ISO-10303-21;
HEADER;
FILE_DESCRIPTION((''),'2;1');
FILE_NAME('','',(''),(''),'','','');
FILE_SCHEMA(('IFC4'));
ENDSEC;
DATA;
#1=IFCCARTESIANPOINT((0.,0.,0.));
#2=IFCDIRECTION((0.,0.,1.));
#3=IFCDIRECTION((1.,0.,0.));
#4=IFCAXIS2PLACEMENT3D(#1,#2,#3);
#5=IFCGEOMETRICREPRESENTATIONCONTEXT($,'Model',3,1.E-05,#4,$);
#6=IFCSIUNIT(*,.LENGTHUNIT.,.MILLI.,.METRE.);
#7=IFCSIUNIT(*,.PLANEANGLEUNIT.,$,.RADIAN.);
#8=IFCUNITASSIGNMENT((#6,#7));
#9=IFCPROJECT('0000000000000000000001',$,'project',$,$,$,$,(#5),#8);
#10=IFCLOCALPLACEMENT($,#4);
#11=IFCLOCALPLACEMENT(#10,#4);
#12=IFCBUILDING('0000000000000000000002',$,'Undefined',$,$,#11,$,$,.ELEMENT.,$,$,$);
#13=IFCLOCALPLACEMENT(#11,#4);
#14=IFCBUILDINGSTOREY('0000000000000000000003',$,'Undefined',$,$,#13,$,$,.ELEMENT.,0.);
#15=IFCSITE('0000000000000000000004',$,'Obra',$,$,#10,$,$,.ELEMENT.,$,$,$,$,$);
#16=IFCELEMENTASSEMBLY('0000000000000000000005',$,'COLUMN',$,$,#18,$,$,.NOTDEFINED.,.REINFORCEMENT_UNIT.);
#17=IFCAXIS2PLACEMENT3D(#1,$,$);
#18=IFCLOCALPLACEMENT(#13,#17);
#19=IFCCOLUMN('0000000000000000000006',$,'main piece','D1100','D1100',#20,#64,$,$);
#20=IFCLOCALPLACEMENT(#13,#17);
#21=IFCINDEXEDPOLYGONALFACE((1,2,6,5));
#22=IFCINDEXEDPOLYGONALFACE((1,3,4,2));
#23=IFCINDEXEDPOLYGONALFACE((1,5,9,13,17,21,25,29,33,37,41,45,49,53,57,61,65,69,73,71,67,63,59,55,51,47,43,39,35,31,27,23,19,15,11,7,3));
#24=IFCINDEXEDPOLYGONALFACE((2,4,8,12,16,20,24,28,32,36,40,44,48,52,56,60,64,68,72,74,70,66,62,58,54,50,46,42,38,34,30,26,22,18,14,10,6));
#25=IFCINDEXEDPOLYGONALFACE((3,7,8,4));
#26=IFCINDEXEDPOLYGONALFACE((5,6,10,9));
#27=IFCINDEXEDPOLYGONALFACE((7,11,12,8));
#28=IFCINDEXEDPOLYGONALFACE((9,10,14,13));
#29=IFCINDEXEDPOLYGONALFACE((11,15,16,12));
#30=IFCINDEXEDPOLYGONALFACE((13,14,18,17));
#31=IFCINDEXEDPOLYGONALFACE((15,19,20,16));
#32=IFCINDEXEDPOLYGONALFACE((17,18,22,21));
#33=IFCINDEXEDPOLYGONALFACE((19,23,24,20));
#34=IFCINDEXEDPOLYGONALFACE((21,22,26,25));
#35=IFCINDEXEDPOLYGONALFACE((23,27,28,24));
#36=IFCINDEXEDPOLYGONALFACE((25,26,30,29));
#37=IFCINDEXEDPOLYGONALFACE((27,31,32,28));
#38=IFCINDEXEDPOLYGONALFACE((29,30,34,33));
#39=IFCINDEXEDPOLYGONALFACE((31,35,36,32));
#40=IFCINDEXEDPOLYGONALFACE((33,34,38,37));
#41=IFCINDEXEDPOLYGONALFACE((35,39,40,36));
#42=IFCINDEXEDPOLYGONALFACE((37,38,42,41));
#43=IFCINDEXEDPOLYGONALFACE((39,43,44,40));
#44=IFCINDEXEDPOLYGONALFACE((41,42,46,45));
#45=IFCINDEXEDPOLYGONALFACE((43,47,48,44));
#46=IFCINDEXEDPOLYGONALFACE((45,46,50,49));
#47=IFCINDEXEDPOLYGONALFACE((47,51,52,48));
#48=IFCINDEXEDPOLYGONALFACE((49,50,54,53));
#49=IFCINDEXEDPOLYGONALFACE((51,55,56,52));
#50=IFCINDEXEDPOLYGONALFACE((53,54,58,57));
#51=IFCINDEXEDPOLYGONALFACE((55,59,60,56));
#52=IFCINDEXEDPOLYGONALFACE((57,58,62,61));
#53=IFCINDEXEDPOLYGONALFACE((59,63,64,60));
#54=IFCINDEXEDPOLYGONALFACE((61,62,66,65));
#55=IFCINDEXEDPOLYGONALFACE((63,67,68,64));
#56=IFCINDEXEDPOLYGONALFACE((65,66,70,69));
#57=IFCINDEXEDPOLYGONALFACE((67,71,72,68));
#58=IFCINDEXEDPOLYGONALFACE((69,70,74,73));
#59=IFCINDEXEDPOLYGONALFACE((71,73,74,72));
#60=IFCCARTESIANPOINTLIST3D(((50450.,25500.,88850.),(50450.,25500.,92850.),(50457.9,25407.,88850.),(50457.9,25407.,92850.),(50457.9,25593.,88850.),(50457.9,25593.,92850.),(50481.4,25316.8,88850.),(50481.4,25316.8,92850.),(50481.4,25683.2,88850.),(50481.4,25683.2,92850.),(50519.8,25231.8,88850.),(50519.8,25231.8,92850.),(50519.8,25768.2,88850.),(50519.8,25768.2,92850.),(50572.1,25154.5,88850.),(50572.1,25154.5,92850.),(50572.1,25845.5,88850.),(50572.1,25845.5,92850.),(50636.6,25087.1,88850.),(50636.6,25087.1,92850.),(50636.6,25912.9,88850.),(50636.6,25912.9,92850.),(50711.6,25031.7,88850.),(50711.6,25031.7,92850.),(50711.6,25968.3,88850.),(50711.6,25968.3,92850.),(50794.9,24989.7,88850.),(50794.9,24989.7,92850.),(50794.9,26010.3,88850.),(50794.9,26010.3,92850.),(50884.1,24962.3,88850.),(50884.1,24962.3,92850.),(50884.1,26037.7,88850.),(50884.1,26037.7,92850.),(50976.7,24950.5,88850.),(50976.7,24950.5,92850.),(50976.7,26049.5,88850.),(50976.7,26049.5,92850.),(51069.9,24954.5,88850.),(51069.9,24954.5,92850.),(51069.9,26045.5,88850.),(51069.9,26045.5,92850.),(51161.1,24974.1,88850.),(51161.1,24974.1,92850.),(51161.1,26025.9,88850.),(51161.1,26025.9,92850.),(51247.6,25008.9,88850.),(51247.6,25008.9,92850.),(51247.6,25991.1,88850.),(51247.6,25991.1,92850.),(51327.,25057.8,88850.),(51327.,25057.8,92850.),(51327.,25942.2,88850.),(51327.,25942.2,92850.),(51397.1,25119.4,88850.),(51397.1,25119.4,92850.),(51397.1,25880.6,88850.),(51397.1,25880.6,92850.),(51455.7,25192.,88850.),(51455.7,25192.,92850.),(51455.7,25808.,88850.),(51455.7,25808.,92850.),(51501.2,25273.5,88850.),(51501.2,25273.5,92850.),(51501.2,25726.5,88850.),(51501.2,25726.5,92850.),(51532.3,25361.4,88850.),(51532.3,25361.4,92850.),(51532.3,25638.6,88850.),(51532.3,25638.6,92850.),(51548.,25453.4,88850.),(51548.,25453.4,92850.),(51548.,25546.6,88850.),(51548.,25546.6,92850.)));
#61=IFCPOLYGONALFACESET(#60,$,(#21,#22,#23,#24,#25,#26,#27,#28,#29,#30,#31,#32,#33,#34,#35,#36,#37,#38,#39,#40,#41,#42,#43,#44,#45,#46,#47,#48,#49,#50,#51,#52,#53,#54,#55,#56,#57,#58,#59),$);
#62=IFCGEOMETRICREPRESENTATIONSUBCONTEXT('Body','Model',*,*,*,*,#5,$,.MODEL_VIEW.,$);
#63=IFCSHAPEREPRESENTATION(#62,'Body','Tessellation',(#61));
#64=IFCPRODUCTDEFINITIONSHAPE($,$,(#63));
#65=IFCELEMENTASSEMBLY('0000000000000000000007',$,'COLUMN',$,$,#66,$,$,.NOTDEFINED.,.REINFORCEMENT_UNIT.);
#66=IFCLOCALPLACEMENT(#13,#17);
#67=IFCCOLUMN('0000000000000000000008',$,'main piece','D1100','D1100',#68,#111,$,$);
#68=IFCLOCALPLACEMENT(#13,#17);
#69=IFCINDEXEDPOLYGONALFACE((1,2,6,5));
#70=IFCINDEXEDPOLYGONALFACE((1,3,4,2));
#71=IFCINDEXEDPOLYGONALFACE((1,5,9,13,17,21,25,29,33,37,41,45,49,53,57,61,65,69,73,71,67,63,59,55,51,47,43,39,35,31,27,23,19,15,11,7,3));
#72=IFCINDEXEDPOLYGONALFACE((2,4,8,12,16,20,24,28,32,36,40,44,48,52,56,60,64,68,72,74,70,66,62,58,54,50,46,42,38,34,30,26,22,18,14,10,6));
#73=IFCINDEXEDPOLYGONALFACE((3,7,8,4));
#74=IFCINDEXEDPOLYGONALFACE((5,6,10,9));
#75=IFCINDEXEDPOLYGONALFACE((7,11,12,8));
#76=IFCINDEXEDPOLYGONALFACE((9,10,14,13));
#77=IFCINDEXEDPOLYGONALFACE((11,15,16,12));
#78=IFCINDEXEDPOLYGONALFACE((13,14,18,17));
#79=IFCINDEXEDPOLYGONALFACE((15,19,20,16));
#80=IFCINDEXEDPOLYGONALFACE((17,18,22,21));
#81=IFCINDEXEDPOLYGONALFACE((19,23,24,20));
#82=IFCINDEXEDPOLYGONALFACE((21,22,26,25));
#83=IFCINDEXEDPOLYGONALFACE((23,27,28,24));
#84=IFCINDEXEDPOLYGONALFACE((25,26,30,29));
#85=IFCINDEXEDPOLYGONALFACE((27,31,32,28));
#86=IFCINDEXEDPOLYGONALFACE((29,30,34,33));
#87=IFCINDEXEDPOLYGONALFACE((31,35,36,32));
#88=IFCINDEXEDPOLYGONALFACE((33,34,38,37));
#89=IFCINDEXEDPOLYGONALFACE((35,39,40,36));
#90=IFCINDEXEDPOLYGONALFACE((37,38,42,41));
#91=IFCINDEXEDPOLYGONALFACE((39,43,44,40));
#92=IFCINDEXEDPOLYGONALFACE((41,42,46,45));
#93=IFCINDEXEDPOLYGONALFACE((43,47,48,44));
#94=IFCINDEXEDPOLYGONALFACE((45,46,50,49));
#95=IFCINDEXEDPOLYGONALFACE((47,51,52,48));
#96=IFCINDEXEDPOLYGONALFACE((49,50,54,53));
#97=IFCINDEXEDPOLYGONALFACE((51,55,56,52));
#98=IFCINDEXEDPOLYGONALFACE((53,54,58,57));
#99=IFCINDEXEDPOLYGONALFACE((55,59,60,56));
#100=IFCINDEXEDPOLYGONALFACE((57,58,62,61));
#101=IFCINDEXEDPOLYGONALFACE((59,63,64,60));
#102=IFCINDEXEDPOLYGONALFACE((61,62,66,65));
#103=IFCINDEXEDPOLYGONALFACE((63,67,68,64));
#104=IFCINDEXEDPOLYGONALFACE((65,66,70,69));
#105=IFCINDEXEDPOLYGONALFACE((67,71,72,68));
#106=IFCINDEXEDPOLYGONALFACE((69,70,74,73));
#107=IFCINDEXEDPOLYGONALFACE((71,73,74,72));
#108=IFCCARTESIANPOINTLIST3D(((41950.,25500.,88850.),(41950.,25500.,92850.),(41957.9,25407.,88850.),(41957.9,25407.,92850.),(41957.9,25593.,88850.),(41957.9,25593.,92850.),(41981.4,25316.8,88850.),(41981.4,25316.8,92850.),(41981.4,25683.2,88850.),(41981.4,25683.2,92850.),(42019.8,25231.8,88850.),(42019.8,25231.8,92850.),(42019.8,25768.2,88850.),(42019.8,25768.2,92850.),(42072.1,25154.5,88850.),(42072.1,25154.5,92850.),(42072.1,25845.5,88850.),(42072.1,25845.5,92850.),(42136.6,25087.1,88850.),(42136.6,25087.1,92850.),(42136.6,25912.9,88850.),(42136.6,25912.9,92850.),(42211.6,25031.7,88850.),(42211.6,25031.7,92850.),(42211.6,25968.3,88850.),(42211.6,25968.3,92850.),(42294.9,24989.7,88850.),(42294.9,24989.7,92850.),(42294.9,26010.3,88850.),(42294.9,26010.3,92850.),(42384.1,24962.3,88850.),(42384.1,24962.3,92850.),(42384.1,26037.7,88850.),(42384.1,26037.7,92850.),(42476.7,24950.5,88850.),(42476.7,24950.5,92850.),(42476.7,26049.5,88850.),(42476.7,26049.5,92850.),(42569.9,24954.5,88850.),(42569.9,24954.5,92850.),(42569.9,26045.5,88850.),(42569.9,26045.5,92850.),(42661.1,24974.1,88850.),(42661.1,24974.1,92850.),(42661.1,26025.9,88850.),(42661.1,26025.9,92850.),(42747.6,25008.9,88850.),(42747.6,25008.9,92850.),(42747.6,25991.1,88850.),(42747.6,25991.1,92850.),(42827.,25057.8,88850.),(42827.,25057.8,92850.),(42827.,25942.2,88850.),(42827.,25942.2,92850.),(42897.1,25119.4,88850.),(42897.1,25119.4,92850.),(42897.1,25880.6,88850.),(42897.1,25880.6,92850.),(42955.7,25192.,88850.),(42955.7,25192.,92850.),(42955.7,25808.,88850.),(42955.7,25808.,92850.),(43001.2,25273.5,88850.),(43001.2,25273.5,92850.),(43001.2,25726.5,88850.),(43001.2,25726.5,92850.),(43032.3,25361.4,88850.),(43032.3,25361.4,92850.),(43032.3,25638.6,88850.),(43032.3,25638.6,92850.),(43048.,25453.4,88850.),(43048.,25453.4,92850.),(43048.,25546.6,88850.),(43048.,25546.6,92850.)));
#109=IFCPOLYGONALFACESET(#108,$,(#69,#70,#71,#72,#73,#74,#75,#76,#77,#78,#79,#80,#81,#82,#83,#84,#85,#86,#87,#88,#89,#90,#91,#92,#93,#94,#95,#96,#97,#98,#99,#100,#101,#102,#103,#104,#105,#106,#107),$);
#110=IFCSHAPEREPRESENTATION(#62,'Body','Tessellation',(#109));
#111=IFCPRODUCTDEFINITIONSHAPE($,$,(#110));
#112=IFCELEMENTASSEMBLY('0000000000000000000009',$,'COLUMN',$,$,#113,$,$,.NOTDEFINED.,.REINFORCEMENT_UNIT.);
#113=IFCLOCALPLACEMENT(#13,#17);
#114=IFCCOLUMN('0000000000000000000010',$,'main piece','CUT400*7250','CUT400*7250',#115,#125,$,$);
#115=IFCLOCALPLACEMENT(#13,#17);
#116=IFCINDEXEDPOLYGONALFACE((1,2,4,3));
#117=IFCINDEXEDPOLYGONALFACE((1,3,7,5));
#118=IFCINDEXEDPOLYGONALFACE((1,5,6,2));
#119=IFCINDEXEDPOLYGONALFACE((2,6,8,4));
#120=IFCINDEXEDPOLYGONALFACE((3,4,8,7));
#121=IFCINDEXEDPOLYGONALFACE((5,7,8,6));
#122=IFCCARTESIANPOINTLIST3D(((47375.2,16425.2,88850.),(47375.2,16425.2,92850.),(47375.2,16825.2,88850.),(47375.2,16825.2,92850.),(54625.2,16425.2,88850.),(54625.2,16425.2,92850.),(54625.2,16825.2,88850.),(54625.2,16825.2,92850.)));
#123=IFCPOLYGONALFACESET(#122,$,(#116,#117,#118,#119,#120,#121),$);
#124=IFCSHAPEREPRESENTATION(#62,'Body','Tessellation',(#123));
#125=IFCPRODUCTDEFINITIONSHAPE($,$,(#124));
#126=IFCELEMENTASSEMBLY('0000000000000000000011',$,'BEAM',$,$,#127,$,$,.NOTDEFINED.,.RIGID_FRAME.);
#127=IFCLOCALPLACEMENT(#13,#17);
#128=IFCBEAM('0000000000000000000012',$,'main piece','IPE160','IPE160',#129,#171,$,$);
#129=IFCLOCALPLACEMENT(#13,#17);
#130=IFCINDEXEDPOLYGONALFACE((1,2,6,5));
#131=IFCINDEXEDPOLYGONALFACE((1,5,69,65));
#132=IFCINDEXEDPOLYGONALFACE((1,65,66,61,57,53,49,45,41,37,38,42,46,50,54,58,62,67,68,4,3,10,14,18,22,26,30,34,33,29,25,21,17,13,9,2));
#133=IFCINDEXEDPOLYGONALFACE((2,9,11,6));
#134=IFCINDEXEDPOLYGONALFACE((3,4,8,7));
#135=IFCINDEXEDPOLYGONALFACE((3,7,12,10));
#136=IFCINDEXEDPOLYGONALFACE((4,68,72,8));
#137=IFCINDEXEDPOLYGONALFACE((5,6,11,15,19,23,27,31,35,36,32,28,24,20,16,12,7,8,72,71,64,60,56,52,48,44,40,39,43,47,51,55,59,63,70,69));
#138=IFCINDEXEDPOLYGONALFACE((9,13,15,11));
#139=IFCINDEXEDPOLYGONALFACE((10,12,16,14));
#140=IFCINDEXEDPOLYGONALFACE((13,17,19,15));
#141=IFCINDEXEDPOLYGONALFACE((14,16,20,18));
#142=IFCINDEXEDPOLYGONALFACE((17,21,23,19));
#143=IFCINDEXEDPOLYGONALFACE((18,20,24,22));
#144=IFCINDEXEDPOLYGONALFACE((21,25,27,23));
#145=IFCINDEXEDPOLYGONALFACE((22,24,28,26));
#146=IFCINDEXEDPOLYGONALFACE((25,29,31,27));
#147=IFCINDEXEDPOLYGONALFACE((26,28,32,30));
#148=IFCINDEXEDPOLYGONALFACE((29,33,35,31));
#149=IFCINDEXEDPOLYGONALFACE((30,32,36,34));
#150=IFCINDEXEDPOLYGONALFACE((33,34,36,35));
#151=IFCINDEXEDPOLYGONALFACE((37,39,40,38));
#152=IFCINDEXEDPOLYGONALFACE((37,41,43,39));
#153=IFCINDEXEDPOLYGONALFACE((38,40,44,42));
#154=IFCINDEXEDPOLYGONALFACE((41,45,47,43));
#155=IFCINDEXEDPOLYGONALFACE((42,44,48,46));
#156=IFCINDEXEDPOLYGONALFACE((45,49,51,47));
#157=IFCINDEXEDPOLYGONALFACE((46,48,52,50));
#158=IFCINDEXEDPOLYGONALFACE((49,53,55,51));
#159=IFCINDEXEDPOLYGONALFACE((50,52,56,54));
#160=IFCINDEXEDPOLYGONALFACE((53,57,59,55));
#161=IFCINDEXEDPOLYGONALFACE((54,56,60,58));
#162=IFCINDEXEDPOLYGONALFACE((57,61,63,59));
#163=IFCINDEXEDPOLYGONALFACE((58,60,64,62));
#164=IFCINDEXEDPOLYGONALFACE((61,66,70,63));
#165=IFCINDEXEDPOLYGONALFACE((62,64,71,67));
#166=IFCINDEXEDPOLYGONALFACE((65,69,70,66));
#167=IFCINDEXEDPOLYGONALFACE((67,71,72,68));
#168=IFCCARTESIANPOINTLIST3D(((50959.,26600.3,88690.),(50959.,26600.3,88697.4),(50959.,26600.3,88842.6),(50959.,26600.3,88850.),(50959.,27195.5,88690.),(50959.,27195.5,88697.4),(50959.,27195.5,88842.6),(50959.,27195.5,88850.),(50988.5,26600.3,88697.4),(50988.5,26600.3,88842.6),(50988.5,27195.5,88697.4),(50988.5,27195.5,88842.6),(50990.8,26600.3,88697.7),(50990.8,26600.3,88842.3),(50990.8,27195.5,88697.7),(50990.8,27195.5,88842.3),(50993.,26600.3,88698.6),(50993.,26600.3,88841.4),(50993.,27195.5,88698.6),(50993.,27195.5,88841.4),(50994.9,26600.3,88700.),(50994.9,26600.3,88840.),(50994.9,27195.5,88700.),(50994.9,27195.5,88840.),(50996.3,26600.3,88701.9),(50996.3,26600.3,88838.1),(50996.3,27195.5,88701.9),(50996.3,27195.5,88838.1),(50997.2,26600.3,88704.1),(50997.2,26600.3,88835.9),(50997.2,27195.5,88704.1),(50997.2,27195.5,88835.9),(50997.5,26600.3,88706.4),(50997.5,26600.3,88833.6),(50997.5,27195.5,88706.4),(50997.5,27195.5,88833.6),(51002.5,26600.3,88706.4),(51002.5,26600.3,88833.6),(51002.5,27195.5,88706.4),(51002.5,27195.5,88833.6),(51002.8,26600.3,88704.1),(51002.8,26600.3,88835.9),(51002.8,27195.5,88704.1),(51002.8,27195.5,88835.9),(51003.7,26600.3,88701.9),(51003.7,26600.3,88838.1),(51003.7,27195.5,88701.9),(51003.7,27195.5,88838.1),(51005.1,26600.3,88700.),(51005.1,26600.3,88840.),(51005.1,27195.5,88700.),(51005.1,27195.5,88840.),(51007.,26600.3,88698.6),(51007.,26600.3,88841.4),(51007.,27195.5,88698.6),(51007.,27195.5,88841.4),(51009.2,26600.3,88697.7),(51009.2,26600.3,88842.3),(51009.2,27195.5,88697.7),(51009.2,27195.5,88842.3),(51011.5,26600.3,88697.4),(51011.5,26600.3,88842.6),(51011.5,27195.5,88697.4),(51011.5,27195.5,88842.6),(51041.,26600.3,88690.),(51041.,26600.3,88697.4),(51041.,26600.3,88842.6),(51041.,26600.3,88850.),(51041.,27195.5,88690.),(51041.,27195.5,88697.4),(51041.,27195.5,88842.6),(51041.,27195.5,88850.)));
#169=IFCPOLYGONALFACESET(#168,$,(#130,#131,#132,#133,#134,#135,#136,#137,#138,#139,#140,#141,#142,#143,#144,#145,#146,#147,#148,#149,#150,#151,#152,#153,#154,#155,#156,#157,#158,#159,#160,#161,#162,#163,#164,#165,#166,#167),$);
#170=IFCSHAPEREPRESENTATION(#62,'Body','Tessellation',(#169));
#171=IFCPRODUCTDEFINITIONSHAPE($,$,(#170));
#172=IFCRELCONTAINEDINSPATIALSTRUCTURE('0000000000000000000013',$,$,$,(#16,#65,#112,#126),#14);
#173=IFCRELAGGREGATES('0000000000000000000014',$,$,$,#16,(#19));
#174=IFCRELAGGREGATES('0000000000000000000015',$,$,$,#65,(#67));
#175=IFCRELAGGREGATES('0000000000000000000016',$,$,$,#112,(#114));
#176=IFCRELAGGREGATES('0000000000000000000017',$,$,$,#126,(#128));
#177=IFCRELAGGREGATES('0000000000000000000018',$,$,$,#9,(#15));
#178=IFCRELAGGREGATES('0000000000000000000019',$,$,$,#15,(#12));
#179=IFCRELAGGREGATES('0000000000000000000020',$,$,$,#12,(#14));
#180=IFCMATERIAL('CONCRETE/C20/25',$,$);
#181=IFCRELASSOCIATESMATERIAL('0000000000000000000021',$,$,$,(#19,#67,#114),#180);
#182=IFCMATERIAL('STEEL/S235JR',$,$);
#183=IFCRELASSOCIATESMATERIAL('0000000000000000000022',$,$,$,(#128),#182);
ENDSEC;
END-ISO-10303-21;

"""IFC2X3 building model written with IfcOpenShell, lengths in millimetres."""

from ifc_helpers import new_model, si_unit, frame, origin_with_axes, origin_2d_with_axis, place, context, subcontext, project, spatial, rectangle, circle, i_section, extrude, material, element, aggregate, save


model = new_model("IFC2X3")

# Units and contexts
model_context = context("Model", 3, precision=1e-05, world=origin_with_axes())
body_context = subcontext(model_context, "Body", "Model", "MODEL_VIEW")
ifc_project = project(units=[si_unit("LENGTHUNIT", "METRE", prefix="MILLI"), si_unit("PLANEANGLEUNIT", "RADIAN")], contexts=[model_context])

# Site, building, storey
site_placement = place(None, origin_with_axes())
site = spatial("IfcSite", under=ifc_project, at=site_placement, Name="Obra", CompositionType="ELEMENT")
building_placement = place(site_placement, origin_with_axes())
building = spatial("IfcBuilding", under=site, at=building_placement, Name="Undefined", CompositionType="ELEMENT")
storey_placement = place(building_placement, origin_with_axes())
storey = spatial("IfcBuildingStorey", under=building, at=storey_placement, Name="Undefined", CompositionType="ELEMENT", Elevation=0.0)

# Element assemblies, columns
assembly_1_placement = place(storey_placement, origin_with_axes())
assembly_1 = element("IfcElementAssembly", 1, at=assembly_1_placement, inside=storey, Name="COLUMN", AssemblyPlace="NOTDEFINED", PredefinedType="REINFORCEMENT_UNIT")
ifc_material_1 = material(Name="CONCRETE/C20/25")
column_1_placement = place(assembly_1_placement, frame((51000.0, 25500.0, 88850.0), z_axis=(0.0, 0.0, 1.0), x_axis=(0.0, 1.0, 0.0)))
column_1 = element("IfcColumn", 2, at=column_1_placement, material=ifc_material_1, Name="main piece", Description="D1100", ObjectType="D1100", context=body_context, shape_type="SweptSolid", body=[
    extrude(circle(Radius=550.0, at=origin_2d_with_axis()), frame((0.0, 0.0, 4000.0), z_axis=(0.0, 0.0, -1.0), x_axis=(0.0, 1.0, 0.0)), (0.0, 0.0, 1.0), 4000.0),
])
aggregate(assembly_1, [column_1])
assembly_2_placement = place(storey_placement, origin_with_axes())
assembly_2 = element("IfcElementAssembly", 3, at=assembly_2_placement, inside=storey, Name="COLUMN", AssemblyPlace="NOTDEFINED", PredefinedType="REINFORCEMENT_UNIT")
column_2_placement = place(assembly_2_placement, frame((42500.0, 25500.0, 88850.0), z_axis=(0.0, 0.0, 1.0), x_axis=(0.0, 1.0, 0.0)))
column_2 = element("IfcColumn", 4, at=column_2_placement, material=ifc_material_1, Name="main piece", Description="D1100", ObjectType="D1100", context=body_context, shape_type="SweptSolid", body=[
    extrude(circle(Radius=550.0, at=origin_2d_with_axis()), frame((0.0, 0.0, 4000.0), z_axis=(0.0, 0.0, -1.0), x_axis=(0.0, 1.0, 0.0)), (0.0, 0.0, 1.0), 4000.0),
])
aggregate(assembly_2, [column_2])
assembly_3_placement = place(storey_placement, origin_with_axes())
assembly_3 = element("IfcElementAssembly", 5, at=assembly_3_placement, inside=storey, Name="COLUMN", AssemblyPlace="NOTDEFINED", PredefinedType="REINFORCEMENT_UNIT")
column_3_placement = place(assembly_3_placement, frame((51000.2, 16625.2, 88850.0), z_axis=(0.0, 0.0, 1.0), x_axis=(-1.0, 0.0, 0.0)))
column_3 = element("IfcColumn", 6, at=column_3_placement, material=ifc_material_1, Name="main piece", Description="CUT400*7250", ObjectType="CUT400*7250", context=body_context, shape_type="SweptSolid", body=[
    extrude(rectangle(XDim=400.0, YDim=7250.0, at=origin_2d_with_axis()), frame((0.0, 0.0, 4000.0), z_axis=(0.0, 0.0, -1.0), x_axis=(0.0, 1.0, 0.0)), (0.0, 0.0, 1.0), 4000.0),
])
aggregate(assembly_3, [column_3])

# Element assembly, beam
assembly_4_placement = place(storey_placement, origin_with_axes())
assembly_4 = element("IfcElementAssembly", 7, at=assembly_4_placement, inside=storey, Name="BEAM", AssemblyPlace="NOTDEFINED", PredefinedType="RIGID_FRAME")
ifc_material_2 = material(Name="STEEL/S235JR")
beam_1_placement = place(assembly_4_placement, frame((51000.0, 26600.3, 88770.0), z_axis=(0.0, 0.0, 1.0), x_axis=(0.0, 1.0, 0.0)))
beam_1 = element("IfcBeam", 8, at=beam_1_placement, material=ifc_material_2, Name="main piece", Description="IPE160", ObjectType="IPE160", context=body_context, shape_type="SweptSolid", body=[
    extrude(i_section(OverallWidth=82.0, OverallDepth=160.0, WebThickness=5.0, FlangeThickness=7.4, FilletRadius=9.0, at=origin_2d_with_axis()), frame((595.2, 0.0, 0.0), z_axis=(-1.0, 0.0, 0.0), x_axis=(0.0, -1.0, 0.0)), (0.0, 0.0, 1.0), 595.2),
])
aggregate(assembly_4, [beam_1])

save(model, "model.ifc")
